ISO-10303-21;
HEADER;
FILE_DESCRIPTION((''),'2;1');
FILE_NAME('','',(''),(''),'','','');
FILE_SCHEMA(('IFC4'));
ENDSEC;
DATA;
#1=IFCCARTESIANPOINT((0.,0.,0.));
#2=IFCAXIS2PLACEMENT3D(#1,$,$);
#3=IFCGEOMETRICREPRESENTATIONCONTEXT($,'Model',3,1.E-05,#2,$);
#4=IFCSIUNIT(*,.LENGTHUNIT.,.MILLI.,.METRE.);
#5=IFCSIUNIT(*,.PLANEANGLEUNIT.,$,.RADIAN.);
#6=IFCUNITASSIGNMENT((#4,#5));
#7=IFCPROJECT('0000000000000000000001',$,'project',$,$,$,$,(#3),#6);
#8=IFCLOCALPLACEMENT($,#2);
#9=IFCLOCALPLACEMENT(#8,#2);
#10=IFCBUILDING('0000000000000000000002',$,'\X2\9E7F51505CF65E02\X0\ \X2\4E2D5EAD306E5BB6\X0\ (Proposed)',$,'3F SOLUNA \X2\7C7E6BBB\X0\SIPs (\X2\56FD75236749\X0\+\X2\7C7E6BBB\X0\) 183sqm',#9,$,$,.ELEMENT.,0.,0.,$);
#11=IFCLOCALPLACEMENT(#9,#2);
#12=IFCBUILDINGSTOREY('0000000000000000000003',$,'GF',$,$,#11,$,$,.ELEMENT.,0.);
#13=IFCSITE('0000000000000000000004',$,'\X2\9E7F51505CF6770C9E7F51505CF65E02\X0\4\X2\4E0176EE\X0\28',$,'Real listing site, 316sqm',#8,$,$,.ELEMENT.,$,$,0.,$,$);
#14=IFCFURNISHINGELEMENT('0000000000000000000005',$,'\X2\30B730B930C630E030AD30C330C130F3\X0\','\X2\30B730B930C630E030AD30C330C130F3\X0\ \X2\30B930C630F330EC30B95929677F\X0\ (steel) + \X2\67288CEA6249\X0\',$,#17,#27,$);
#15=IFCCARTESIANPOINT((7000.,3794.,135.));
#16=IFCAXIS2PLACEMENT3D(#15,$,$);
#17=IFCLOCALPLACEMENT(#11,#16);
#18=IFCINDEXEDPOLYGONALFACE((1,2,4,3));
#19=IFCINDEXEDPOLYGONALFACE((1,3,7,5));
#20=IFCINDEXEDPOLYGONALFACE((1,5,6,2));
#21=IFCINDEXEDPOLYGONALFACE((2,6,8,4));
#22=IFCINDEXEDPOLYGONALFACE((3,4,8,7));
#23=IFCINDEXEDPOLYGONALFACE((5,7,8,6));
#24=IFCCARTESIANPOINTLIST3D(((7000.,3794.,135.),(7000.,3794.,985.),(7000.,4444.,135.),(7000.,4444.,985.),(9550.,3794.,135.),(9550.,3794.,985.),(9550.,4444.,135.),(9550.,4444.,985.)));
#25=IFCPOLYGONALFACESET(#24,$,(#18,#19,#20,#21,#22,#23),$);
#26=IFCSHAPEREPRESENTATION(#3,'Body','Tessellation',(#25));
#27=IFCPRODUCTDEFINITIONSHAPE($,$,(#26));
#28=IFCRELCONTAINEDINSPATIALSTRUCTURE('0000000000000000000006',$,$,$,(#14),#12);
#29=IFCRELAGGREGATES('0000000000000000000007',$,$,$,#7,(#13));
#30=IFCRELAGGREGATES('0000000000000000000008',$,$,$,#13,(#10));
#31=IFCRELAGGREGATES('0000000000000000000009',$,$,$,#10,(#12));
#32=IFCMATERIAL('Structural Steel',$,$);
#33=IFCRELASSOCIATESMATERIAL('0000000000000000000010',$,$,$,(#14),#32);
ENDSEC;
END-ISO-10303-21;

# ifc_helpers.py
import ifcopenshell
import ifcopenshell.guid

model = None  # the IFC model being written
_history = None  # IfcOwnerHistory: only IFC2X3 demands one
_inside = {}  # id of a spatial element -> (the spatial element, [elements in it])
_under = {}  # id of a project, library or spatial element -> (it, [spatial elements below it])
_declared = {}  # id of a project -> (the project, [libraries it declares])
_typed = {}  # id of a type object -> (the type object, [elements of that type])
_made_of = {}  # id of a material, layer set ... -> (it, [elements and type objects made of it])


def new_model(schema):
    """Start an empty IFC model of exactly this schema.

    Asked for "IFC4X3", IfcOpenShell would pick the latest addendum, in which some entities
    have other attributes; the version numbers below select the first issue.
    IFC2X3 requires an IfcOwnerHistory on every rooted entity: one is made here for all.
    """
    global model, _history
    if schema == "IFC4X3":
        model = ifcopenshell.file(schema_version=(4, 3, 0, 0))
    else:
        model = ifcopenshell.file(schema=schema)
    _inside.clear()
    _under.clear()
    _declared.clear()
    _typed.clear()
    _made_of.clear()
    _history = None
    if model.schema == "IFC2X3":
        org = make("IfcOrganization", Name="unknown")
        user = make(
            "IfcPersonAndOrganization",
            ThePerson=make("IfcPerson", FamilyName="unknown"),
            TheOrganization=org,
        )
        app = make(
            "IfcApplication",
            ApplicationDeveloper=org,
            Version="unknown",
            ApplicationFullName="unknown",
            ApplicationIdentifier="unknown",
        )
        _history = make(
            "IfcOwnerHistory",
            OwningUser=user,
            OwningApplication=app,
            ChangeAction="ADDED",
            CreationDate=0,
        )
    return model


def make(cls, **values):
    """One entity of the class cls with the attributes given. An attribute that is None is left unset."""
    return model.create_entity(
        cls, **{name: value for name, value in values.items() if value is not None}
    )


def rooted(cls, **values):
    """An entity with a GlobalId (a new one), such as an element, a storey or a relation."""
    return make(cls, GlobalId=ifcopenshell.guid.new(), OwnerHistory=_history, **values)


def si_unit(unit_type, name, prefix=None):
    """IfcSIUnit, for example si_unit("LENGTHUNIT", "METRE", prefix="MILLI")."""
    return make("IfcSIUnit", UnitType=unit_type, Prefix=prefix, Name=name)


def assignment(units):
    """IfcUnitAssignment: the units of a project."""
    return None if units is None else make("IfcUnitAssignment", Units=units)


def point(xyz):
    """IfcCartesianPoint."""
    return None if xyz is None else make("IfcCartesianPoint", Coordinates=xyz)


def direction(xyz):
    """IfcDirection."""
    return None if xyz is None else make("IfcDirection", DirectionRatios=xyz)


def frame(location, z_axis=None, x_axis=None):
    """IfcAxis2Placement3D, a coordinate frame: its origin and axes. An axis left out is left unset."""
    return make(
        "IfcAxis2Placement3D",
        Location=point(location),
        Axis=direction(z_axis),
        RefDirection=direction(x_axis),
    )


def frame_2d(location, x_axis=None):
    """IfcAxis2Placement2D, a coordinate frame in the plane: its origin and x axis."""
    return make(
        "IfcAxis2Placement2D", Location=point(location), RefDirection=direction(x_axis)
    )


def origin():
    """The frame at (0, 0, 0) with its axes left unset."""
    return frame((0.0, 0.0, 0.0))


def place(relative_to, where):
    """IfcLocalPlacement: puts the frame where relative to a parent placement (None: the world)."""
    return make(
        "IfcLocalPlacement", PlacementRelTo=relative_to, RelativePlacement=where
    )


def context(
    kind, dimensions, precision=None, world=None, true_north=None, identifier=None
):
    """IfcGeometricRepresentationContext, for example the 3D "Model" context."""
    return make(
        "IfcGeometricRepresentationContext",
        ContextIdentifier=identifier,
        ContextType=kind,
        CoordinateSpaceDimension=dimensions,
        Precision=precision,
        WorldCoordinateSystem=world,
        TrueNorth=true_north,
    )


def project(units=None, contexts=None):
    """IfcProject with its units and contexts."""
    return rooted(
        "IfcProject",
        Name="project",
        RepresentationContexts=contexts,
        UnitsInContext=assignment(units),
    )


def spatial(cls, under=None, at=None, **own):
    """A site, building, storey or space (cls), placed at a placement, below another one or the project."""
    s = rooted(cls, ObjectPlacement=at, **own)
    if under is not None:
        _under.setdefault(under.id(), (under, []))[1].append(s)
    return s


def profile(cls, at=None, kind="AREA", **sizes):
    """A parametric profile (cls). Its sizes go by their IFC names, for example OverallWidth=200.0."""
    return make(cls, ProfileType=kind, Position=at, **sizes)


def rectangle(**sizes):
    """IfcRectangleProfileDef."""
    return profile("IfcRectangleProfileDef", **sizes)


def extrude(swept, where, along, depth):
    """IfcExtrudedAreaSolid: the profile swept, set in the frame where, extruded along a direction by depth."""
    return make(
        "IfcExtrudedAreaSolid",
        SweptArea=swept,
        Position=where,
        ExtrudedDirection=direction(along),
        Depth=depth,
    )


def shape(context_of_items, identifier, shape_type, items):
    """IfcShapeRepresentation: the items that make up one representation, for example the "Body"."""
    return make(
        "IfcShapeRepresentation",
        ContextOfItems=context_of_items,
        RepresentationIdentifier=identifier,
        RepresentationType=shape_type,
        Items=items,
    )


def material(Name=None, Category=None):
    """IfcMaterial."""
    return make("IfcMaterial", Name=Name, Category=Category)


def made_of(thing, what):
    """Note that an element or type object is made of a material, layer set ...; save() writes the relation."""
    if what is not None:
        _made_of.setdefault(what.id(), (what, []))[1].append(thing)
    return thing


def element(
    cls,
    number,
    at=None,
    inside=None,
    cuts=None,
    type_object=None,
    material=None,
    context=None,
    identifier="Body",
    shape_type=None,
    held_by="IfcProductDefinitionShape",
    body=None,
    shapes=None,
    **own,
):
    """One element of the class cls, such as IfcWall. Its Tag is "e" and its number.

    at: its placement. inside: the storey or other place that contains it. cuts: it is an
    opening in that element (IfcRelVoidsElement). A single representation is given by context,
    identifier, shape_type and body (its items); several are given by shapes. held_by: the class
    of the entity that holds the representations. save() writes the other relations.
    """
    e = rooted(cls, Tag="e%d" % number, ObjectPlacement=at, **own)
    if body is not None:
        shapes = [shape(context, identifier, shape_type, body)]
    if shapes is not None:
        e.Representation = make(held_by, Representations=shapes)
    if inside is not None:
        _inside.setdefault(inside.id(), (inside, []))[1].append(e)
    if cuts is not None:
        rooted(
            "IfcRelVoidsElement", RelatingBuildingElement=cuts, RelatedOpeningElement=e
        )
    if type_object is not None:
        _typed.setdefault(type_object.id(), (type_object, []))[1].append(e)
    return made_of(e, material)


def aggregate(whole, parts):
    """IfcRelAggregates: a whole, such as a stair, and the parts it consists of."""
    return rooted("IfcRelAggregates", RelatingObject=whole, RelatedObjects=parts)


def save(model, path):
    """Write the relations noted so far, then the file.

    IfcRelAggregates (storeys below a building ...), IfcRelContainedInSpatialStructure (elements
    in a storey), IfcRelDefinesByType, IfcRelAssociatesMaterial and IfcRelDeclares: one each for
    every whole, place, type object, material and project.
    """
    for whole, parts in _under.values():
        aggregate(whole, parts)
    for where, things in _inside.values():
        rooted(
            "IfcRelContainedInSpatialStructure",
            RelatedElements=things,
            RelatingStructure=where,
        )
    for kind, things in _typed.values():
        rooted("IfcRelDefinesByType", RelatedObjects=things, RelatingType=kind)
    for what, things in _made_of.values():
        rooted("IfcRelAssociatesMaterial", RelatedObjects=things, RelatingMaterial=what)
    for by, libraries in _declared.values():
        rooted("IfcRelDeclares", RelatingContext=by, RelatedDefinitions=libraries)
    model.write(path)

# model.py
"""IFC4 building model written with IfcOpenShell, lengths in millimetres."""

from ifc_helpers import new_model, si_unit, frame, frame_2d, origin, place, context, project, spatial, rectangle, extrude, material, element, save


model = new_model("IFC4")

# Units and contexts
model_context = context("Model", 3, precision=1e-05, world=origin())
ifc_project = project(units=[si_unit("LENGTHUNIT", "METRE", prefix="MILLI"), si_unit("PLANEANGLEUNIT", "RADIAN")], contexts=[model_context])

# Site, building, storey
site_placement = place(None, origin())
site = spatial("IfcSite", under=ifc_project, at=site_placement, Name="鹿児島県鹿児島市4丁目28", ObjectType="Real listing site, 316sqm", CompositionType="ELEMENT", RefElevation=0.0)
building_placement = place(site_placement, origin())
building = spatial("IfcBuilding", under=site, at=building_placement, Name="鹿児島市 中庭の家 (Proposed)", ObjectType="3F SOLUNA 籾殻SIPs (国産杉+籾殻) 183sqm", CompositionType="ELEMENT", ElevationOfRefHeight=0.0, ElevationOfTerrain=0.0)
storey_placement = place(building_placement, origin())
storey = spatial("IfcBuildingStorey", under=building, at=storey_placement, Name="GF", CompositionType="ELEMENT", Elevation=0.0)

# Furnishing element
ifc_material_1 = material(Name="Structural Steel")
furnishing_1_placement = place(storey_placement, frame((7000.0, 3794.0, 135.0)))
element("IfcFurnishingElement", 1, at=furnishing_1_placement, inside=storey, material=ifc_material_1, Name="システムキッチン", Description="システムキッチン ステンレス天板 (steel) + 木質扉", context=model_context, shape_type="SweptSolid", body=[
    extrude(rectangle(XDim=2550.0, YDim=650.0, at=frame_2d((1275.0, 325.0))), frame((7000.0, 3794.0, 135.0)), (0.0, 0.0, 1.0), 850.0),
])

save(model, "model.ifc")
